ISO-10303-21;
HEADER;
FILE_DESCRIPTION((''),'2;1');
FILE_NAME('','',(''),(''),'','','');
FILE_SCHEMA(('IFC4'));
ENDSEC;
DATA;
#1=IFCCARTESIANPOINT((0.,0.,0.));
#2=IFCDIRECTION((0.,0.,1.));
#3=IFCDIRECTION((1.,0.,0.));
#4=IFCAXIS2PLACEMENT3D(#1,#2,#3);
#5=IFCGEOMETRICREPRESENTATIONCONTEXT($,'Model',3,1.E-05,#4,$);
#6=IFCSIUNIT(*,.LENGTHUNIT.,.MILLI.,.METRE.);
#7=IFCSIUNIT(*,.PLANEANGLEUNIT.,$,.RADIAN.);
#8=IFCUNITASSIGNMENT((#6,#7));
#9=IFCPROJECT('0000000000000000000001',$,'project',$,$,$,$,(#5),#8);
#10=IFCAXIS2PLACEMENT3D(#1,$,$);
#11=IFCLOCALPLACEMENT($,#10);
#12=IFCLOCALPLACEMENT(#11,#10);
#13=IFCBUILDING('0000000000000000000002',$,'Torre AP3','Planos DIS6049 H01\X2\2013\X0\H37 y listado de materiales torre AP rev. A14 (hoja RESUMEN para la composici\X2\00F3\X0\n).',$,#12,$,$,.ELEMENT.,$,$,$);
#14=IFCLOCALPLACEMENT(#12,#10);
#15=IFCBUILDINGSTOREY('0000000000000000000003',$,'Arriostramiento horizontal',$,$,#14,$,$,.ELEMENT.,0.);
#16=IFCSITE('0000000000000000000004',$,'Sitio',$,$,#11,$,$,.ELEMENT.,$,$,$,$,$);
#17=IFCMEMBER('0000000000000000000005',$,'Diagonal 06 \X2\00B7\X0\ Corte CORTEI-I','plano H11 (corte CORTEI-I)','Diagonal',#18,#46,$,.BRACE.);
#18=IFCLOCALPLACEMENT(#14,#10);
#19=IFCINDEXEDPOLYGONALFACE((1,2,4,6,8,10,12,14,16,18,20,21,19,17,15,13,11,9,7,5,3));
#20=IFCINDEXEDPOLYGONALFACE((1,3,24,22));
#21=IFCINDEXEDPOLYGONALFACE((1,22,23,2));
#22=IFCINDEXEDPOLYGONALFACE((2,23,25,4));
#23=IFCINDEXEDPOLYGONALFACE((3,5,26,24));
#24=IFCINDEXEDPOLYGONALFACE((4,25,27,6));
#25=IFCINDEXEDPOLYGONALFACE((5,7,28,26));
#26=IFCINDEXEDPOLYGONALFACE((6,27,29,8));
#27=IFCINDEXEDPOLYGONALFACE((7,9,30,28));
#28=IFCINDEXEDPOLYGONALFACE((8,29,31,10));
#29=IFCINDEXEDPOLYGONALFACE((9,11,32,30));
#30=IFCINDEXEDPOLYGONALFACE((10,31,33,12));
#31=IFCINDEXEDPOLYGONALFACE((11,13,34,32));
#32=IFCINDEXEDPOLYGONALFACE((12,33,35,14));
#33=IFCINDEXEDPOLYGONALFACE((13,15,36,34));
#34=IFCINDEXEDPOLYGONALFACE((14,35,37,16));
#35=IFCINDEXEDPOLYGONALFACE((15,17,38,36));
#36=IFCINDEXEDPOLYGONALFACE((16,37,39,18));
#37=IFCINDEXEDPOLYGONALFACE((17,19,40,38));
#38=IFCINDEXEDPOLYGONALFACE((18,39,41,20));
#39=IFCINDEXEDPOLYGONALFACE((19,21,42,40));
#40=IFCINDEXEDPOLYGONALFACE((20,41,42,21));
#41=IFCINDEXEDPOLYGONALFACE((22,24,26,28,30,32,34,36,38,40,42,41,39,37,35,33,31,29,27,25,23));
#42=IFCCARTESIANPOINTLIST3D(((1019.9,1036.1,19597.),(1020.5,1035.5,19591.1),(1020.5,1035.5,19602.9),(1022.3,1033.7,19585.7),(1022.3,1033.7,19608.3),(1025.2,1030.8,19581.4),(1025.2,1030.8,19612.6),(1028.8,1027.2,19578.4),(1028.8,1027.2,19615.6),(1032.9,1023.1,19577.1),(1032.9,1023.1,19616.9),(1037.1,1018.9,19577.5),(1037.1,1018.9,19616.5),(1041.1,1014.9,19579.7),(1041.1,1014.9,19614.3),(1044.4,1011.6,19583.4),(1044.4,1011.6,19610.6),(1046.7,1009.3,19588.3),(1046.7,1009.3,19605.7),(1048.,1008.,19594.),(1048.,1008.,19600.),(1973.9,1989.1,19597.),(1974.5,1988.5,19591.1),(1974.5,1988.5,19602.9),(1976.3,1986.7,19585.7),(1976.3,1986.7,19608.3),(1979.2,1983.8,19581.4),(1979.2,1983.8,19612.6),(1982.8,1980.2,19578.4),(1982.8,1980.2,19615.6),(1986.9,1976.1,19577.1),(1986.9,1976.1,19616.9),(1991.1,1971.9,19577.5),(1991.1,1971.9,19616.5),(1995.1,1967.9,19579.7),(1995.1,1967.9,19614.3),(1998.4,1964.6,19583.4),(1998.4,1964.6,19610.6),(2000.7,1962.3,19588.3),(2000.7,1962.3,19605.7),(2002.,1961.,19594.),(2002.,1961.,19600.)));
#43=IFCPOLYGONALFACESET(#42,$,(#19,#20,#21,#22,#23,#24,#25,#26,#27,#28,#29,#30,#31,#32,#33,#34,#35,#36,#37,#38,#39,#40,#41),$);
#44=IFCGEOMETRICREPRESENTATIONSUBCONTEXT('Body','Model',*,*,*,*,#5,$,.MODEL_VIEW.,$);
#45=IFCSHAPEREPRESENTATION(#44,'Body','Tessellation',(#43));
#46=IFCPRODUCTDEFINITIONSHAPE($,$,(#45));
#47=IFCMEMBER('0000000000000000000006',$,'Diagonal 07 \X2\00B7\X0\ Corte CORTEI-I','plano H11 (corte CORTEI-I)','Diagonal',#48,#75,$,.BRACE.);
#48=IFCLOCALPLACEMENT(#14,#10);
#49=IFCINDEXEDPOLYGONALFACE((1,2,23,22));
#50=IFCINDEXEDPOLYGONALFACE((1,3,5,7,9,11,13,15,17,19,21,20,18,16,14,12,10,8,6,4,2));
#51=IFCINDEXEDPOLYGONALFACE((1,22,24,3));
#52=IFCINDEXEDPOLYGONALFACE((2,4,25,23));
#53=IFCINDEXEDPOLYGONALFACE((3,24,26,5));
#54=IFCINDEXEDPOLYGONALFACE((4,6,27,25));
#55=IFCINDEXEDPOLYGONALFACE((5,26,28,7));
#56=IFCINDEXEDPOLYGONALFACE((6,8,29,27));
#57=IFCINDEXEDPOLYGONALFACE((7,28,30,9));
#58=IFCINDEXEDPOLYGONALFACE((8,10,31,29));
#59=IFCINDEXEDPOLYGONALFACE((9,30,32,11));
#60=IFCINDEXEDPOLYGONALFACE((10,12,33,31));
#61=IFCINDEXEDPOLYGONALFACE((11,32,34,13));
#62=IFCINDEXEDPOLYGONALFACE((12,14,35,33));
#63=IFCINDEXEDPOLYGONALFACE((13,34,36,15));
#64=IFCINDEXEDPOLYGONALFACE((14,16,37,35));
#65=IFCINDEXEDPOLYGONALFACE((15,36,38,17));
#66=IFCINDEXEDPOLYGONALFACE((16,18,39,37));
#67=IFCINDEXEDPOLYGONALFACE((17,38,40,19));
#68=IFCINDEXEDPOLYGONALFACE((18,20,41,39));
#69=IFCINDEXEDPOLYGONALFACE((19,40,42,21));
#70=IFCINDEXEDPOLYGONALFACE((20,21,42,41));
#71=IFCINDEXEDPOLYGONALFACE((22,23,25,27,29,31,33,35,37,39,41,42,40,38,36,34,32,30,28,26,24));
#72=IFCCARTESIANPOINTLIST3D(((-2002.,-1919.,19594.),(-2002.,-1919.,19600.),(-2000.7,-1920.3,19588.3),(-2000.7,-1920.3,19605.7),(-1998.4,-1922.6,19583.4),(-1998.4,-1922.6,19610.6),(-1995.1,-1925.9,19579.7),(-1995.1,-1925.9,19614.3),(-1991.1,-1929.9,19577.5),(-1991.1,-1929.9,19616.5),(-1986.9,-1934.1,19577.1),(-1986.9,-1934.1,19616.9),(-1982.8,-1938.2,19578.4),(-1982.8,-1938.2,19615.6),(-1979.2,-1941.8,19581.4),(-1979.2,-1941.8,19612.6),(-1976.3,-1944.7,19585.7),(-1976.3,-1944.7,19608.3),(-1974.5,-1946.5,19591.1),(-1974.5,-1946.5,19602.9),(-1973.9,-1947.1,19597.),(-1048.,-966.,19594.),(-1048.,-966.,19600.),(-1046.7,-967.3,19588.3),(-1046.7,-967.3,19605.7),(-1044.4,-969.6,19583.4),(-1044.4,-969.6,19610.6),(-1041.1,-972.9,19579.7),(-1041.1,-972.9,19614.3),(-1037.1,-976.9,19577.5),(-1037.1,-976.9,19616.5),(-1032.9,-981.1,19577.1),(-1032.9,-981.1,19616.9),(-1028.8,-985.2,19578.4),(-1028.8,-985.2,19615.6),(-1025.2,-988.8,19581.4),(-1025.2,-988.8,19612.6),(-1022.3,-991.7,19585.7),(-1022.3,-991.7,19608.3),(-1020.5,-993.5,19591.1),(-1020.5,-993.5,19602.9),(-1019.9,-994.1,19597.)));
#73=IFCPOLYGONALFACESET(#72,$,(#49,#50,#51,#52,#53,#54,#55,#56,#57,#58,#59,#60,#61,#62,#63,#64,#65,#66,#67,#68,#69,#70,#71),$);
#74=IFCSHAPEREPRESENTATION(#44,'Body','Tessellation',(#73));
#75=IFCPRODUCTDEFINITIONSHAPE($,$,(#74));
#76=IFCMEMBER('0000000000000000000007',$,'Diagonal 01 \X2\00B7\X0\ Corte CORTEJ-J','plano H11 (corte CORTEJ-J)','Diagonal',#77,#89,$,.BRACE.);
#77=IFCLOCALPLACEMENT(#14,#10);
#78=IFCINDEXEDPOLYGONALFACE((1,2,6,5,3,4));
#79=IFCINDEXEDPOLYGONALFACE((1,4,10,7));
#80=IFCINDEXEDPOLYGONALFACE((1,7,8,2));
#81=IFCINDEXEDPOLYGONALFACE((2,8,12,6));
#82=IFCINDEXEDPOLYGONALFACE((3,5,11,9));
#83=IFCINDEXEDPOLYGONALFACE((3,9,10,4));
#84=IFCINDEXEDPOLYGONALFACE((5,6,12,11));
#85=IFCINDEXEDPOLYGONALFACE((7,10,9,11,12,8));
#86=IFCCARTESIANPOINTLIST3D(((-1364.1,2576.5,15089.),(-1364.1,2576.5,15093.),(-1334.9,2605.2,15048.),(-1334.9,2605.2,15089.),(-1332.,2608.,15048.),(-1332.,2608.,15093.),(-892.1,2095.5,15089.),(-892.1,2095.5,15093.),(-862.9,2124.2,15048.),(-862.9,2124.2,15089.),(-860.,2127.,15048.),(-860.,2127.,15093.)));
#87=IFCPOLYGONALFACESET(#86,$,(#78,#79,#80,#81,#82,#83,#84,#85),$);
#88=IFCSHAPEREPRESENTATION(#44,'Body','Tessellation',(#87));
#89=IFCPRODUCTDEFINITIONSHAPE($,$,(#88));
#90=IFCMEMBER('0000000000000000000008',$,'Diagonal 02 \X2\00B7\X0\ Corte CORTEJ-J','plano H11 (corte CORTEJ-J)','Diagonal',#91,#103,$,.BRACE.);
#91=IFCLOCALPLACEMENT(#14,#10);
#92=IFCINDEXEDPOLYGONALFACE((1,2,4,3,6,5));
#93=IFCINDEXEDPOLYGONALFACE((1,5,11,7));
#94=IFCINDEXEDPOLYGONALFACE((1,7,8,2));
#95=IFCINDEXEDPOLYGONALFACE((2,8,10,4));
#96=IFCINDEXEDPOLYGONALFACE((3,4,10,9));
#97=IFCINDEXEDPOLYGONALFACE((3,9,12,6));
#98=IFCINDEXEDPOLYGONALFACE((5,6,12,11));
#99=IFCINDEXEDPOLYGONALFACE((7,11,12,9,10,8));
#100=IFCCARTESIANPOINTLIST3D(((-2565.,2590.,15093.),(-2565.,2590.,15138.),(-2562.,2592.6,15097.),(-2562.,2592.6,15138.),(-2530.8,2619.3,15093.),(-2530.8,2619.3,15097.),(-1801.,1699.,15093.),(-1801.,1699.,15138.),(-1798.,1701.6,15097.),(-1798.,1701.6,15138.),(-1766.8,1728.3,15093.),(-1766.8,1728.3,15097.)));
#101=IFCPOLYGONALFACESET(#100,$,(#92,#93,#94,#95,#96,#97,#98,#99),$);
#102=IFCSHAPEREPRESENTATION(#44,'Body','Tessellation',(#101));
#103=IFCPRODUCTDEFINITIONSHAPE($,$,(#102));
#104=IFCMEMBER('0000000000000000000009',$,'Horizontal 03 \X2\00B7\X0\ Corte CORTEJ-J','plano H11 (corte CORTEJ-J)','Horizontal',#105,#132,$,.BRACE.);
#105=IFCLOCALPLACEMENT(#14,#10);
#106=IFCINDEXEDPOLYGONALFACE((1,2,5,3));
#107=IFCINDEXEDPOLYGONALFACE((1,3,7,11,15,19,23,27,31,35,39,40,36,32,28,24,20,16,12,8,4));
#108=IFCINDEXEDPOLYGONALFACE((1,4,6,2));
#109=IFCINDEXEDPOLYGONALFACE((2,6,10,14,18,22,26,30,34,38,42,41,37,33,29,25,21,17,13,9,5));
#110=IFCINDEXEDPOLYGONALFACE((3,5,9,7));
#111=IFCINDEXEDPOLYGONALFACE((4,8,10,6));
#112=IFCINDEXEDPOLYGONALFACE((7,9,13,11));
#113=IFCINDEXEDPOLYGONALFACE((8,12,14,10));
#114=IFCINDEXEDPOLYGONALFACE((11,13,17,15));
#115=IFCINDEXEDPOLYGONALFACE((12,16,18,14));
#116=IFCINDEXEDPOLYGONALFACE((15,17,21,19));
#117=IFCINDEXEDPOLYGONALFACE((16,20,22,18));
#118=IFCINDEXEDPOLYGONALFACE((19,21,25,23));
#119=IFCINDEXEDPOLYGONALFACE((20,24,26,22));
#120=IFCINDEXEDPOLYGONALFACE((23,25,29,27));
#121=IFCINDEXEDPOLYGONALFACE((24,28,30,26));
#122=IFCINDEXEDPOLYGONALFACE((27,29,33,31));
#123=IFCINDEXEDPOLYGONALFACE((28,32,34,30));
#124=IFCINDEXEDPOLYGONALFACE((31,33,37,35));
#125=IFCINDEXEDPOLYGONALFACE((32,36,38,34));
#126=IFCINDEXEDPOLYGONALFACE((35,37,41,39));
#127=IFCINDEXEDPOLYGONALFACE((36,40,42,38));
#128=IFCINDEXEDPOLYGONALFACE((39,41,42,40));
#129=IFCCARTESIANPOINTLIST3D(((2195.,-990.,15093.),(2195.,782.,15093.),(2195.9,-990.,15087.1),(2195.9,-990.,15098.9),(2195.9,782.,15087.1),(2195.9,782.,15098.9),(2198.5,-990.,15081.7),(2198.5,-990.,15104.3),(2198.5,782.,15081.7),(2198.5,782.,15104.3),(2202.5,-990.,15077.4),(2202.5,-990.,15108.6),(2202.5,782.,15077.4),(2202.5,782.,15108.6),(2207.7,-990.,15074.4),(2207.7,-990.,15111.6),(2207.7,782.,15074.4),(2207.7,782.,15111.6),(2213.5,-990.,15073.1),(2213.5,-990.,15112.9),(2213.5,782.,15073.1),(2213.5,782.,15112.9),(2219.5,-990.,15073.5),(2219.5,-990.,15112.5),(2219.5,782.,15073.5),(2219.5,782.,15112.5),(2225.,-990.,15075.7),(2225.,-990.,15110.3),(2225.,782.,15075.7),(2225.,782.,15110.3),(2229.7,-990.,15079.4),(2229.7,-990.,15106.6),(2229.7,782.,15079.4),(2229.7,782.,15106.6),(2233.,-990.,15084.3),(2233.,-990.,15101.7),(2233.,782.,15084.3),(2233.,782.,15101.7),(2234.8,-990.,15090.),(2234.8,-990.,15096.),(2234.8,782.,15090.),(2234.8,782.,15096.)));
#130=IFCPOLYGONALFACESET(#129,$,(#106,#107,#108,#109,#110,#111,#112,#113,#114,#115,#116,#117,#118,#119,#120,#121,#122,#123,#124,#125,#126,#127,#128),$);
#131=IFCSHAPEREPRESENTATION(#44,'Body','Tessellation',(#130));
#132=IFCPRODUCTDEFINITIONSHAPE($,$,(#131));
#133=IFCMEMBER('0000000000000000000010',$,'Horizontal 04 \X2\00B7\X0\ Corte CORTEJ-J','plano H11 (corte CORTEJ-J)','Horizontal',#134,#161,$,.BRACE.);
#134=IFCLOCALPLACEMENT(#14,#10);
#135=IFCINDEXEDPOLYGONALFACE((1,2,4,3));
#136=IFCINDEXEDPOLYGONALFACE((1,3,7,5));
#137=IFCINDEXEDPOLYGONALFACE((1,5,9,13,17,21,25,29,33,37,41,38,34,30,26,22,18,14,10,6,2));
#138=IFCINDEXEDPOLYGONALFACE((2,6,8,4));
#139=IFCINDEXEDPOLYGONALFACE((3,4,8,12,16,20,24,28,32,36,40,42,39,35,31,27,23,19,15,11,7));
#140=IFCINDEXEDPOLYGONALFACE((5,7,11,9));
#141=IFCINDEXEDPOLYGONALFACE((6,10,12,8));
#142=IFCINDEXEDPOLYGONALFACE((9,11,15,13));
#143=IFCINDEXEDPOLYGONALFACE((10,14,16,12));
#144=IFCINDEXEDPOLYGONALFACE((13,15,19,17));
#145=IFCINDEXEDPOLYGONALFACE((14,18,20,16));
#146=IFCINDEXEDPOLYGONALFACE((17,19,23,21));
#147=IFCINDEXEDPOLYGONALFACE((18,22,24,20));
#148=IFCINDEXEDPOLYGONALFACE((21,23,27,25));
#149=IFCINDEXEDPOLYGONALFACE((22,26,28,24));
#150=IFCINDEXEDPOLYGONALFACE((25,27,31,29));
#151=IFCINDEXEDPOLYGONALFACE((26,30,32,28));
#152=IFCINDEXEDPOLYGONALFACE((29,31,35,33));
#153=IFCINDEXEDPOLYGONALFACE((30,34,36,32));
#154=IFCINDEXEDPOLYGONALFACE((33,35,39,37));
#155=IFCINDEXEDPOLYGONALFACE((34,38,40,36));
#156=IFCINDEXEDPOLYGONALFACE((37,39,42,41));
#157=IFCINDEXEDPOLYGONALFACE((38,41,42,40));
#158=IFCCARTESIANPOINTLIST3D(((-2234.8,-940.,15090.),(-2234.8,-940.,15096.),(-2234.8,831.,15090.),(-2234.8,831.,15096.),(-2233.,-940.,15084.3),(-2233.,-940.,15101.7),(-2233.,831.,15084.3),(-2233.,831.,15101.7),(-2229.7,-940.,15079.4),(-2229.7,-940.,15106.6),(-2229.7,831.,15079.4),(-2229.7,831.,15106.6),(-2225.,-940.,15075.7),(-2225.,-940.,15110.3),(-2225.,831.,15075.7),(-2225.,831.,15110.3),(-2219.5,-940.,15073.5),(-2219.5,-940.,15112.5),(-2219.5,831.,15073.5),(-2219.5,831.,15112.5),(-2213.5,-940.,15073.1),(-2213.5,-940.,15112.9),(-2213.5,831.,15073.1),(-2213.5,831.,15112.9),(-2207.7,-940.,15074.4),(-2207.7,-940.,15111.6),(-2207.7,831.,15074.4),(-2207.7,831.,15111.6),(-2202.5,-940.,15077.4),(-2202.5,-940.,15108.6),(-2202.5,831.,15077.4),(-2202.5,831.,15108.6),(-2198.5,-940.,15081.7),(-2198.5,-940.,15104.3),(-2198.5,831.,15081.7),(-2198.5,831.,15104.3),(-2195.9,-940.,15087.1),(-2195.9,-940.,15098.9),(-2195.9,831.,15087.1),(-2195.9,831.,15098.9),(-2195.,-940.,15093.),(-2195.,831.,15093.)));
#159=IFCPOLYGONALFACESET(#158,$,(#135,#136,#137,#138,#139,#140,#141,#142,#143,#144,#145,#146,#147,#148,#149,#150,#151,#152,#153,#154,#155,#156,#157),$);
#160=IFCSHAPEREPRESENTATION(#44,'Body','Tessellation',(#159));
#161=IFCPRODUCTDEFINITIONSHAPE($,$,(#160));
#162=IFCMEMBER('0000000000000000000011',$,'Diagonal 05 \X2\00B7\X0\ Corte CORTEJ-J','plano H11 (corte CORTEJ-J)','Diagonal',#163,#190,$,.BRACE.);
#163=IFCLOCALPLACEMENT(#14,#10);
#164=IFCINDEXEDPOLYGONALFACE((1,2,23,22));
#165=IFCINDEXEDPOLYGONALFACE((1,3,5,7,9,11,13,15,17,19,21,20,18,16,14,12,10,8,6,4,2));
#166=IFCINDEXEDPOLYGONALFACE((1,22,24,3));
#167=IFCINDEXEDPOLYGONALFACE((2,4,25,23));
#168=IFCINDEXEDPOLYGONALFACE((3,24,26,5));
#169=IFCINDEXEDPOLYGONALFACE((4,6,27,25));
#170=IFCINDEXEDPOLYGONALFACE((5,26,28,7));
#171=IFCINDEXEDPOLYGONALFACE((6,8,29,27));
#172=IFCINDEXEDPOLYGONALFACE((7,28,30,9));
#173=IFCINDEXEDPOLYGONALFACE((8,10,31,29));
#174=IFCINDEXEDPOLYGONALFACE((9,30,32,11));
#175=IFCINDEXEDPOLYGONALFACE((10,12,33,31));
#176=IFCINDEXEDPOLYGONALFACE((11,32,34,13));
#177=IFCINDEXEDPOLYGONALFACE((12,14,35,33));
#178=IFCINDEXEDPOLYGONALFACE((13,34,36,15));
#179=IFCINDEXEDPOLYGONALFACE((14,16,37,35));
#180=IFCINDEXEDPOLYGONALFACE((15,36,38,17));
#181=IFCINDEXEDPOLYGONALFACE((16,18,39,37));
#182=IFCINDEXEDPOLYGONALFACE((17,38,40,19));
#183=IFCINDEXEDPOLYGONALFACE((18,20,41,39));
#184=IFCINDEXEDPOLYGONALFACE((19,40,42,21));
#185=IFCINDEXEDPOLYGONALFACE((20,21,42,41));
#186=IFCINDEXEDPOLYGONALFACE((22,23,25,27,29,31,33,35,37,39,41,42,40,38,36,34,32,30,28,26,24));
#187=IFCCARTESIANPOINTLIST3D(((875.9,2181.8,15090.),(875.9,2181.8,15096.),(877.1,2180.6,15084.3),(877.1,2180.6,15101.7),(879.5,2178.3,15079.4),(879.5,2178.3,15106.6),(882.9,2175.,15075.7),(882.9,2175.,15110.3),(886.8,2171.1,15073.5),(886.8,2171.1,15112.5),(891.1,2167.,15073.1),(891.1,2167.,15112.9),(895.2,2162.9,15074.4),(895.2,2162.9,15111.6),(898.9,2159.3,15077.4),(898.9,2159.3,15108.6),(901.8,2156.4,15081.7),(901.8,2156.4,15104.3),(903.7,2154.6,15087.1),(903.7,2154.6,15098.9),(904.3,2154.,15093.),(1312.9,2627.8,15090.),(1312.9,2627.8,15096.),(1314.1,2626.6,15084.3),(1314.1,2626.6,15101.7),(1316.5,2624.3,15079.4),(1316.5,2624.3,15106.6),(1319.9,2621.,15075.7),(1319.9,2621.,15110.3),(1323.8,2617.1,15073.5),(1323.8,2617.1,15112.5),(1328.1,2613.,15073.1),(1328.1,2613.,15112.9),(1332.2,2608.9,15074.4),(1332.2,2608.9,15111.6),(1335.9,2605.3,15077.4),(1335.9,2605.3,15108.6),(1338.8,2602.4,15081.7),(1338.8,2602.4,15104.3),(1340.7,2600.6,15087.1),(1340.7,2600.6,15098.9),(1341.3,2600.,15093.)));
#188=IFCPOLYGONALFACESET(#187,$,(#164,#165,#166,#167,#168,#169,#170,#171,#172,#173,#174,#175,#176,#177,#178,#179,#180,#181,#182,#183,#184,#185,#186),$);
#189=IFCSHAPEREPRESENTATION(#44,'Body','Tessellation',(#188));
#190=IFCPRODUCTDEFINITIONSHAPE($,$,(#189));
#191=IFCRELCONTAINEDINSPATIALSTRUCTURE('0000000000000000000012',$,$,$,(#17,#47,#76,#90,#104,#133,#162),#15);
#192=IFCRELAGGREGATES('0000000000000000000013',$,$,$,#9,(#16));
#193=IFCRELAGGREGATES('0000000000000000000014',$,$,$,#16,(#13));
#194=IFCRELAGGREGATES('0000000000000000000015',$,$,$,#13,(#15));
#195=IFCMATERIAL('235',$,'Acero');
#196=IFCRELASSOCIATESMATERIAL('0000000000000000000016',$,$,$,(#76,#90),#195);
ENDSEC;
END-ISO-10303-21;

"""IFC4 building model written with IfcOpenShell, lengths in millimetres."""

from ifc_helpers import new_model, si_unit, frame, frame_2d, origin, origin_with_axes, place, context, subcontext, project, spatial, circle, l_section, extrude, material, element, save


model = new_model("IFC4")

# Units and contexts
model_context = context("Model", 3, precision=1e-05, world=origin_with_axes())
body_context = subcontext(model_context, "Body", "Model", "MODEL_VIEW")
ifc_project = project(units=[si_unit("LENGTHUNIT", "METRE", prefix="MILLI"), si_unit("PLANEANGLEUNIT", "RADIAN")], contexts=[model_context])

# Site, building, storey
site_placement = place(None, origin())
site = spatial("IfcSite", under=ifc_project, at=site_placement, Name="Sitio", CompositionType="ELEMENT")
building_placement = place(site_placement, origin())
building = spatial("IfcBuilding", under=site, at=building_placement, Name="Torre AP3", Description="Planos DIS6049 H01–H37 y listado de materiales torre AP rev. A14 (hoja RESUMEN para la composición).", CompositionType="ELEMENT")
storey_placement = place(building_placement, origin())
storey = spatial("IfcBuildingStorey", under=building, at=storey_placement, Name="Arriostramiento horizontal", CompositionType="ELEMENT", Elevation=0.0)

# Members
ifc_material = material(Name="235", Category="Acero")
for number, where, z_axis, x_axis, name in (
    (1, (1988.0, 1975.0, 19597.0), (-0.707477, -0.706736, 0.0), (-0.706736, 0.707477, 0.0), "Diagonal 06 · Corte CORTEI-I"),
    (2, (-1034.0, -980.0, 19597.0), (-0.707477, -0.706736, 0.0), (0.706736, -0.707477, 0.0), "Diagonal 07 · Corte CORTEI-I"),
):
    element("IfcMember", number, at=place(storey_placement, frame(where, z_axis=z_axis, x_axis=x_axis)), inside=storey, Name=name, Description="plano H11 (corte CORTEI-I)", ObjectType="Diagonal", PredefinedType="BRACE", context=body_context, shape_type="SweptSolid", body=[
        extrude(circle(Radius=20.0), None, (0.0, 0.0, 1.0), 1348.5),
    ])
member_1_placement = place(storey_placement, frame((-1332.0, 2608.0, 15093.0), z_axis=(0.700398, -0.713753, 0.0), x_axis=(-0.713753, -0.700398, 0.0)))
element("IfcMember", 3, at=member_1_placement, inside=storey, material=ifc_material, Name="Diagonal 01 · Corte CORTEJ-J", Description="plano H11 (corte CORTEJ-J)", ObjectType="Diagonal", PredefinedType="BRACE", context=body_context, shape_type="SweptSolid", body=[
    extrude(l_section(Depth=45.0, Width=45.0, Thickness=4.0, at=frame_2d((22.5, 22.5))), None, (0.0, 0.0, 1.0), 673.9),
])
member_2_placement = place(storey_placement, frame((-2565.0, 2590.0, 15093.0), z_axis=(0.650932, -0.759136, 0.0), x_axis=(0.759136, 0.650932, 0.0)))
element("IfcMember", 4, at=member_2_placement, inside=storey, material=ifc_material, Name="Diagonal 02 · Corte CORTEJ-J", Description="plano H11 (corte CORTEJ-J)", ObjectType="Diagonal", PredefinedType="BRACE", context=body_context, shape_type="SweptSolid", body=[
    extrude(l_section(Depth=45.0, Width=45.0, Thickness=4.0, at=frame_2d((22.5, 22.5))), None, (0.0, 0.0, 1.0), 1173.7),
])
member_3_placement = place(storey_placement, frame((2215.0, 782.0, 15093.0), z_axis=(0.0, -1.0, 0.0), x_axis=(-1.0, 0.0, 0.0)))
element("IfcMember", 5, at=member_3_placement, inside=storey, Name="Horizontal 03 · Corte CORTEJ-J", Description="plano H11 (corte CORTEJ-J)", ObjectType="Horizontal", PredefinedType="BRACE", context=body_context, shape_type="SweptSolid", body=[
    extrude(circle(Radius=20.0), None, (0.0, 0.0, 1.0), 1772.0),
])
member_4_placement = place(storey_placement, frame((-2215.0, 831.0, 15093.0), z_axis=(0.0, -1.0, 0.0), x_axis=(1.0, 0.0, 0.0)))
element("IfcMember", 6, at=member_4_placement, inside=storey, Name="Horizontal 04 · Corte CORTEJ-J", Description="plano H11 (corte CORTEJ-J)", ObjectType="Horizontal", PredefinedType="BRACE", context=body_context, shape_type="SweptSolid", body=[
    extrude(circle(Radius=20.0), None, (0.0, 0.0, 1.0), 1771.0),
])
member_5_placement = place(storey_placement, frame((1327.0, 2614.0, 15093.0), z_axis=(-0.699863, -0.714277, 0.0), x_axis=(0.714277, -0.699863, 0.0)))
element("IfcMember", 7, at=member_5_placement, inside=storey, Name="Diagonal 05 · Corte CORTEJ-J", Description="plano H11 (corte CORTEJ-J)", ObjectType="Diagonal", PredefinedType="BRACE", context=body_context, shape_type="SweptSolid", body=[
    extrude(circle(Radius=20.0), None, (0.0, 0.0, 1.0), 624.4),
])

save(model, "model.ifc")
